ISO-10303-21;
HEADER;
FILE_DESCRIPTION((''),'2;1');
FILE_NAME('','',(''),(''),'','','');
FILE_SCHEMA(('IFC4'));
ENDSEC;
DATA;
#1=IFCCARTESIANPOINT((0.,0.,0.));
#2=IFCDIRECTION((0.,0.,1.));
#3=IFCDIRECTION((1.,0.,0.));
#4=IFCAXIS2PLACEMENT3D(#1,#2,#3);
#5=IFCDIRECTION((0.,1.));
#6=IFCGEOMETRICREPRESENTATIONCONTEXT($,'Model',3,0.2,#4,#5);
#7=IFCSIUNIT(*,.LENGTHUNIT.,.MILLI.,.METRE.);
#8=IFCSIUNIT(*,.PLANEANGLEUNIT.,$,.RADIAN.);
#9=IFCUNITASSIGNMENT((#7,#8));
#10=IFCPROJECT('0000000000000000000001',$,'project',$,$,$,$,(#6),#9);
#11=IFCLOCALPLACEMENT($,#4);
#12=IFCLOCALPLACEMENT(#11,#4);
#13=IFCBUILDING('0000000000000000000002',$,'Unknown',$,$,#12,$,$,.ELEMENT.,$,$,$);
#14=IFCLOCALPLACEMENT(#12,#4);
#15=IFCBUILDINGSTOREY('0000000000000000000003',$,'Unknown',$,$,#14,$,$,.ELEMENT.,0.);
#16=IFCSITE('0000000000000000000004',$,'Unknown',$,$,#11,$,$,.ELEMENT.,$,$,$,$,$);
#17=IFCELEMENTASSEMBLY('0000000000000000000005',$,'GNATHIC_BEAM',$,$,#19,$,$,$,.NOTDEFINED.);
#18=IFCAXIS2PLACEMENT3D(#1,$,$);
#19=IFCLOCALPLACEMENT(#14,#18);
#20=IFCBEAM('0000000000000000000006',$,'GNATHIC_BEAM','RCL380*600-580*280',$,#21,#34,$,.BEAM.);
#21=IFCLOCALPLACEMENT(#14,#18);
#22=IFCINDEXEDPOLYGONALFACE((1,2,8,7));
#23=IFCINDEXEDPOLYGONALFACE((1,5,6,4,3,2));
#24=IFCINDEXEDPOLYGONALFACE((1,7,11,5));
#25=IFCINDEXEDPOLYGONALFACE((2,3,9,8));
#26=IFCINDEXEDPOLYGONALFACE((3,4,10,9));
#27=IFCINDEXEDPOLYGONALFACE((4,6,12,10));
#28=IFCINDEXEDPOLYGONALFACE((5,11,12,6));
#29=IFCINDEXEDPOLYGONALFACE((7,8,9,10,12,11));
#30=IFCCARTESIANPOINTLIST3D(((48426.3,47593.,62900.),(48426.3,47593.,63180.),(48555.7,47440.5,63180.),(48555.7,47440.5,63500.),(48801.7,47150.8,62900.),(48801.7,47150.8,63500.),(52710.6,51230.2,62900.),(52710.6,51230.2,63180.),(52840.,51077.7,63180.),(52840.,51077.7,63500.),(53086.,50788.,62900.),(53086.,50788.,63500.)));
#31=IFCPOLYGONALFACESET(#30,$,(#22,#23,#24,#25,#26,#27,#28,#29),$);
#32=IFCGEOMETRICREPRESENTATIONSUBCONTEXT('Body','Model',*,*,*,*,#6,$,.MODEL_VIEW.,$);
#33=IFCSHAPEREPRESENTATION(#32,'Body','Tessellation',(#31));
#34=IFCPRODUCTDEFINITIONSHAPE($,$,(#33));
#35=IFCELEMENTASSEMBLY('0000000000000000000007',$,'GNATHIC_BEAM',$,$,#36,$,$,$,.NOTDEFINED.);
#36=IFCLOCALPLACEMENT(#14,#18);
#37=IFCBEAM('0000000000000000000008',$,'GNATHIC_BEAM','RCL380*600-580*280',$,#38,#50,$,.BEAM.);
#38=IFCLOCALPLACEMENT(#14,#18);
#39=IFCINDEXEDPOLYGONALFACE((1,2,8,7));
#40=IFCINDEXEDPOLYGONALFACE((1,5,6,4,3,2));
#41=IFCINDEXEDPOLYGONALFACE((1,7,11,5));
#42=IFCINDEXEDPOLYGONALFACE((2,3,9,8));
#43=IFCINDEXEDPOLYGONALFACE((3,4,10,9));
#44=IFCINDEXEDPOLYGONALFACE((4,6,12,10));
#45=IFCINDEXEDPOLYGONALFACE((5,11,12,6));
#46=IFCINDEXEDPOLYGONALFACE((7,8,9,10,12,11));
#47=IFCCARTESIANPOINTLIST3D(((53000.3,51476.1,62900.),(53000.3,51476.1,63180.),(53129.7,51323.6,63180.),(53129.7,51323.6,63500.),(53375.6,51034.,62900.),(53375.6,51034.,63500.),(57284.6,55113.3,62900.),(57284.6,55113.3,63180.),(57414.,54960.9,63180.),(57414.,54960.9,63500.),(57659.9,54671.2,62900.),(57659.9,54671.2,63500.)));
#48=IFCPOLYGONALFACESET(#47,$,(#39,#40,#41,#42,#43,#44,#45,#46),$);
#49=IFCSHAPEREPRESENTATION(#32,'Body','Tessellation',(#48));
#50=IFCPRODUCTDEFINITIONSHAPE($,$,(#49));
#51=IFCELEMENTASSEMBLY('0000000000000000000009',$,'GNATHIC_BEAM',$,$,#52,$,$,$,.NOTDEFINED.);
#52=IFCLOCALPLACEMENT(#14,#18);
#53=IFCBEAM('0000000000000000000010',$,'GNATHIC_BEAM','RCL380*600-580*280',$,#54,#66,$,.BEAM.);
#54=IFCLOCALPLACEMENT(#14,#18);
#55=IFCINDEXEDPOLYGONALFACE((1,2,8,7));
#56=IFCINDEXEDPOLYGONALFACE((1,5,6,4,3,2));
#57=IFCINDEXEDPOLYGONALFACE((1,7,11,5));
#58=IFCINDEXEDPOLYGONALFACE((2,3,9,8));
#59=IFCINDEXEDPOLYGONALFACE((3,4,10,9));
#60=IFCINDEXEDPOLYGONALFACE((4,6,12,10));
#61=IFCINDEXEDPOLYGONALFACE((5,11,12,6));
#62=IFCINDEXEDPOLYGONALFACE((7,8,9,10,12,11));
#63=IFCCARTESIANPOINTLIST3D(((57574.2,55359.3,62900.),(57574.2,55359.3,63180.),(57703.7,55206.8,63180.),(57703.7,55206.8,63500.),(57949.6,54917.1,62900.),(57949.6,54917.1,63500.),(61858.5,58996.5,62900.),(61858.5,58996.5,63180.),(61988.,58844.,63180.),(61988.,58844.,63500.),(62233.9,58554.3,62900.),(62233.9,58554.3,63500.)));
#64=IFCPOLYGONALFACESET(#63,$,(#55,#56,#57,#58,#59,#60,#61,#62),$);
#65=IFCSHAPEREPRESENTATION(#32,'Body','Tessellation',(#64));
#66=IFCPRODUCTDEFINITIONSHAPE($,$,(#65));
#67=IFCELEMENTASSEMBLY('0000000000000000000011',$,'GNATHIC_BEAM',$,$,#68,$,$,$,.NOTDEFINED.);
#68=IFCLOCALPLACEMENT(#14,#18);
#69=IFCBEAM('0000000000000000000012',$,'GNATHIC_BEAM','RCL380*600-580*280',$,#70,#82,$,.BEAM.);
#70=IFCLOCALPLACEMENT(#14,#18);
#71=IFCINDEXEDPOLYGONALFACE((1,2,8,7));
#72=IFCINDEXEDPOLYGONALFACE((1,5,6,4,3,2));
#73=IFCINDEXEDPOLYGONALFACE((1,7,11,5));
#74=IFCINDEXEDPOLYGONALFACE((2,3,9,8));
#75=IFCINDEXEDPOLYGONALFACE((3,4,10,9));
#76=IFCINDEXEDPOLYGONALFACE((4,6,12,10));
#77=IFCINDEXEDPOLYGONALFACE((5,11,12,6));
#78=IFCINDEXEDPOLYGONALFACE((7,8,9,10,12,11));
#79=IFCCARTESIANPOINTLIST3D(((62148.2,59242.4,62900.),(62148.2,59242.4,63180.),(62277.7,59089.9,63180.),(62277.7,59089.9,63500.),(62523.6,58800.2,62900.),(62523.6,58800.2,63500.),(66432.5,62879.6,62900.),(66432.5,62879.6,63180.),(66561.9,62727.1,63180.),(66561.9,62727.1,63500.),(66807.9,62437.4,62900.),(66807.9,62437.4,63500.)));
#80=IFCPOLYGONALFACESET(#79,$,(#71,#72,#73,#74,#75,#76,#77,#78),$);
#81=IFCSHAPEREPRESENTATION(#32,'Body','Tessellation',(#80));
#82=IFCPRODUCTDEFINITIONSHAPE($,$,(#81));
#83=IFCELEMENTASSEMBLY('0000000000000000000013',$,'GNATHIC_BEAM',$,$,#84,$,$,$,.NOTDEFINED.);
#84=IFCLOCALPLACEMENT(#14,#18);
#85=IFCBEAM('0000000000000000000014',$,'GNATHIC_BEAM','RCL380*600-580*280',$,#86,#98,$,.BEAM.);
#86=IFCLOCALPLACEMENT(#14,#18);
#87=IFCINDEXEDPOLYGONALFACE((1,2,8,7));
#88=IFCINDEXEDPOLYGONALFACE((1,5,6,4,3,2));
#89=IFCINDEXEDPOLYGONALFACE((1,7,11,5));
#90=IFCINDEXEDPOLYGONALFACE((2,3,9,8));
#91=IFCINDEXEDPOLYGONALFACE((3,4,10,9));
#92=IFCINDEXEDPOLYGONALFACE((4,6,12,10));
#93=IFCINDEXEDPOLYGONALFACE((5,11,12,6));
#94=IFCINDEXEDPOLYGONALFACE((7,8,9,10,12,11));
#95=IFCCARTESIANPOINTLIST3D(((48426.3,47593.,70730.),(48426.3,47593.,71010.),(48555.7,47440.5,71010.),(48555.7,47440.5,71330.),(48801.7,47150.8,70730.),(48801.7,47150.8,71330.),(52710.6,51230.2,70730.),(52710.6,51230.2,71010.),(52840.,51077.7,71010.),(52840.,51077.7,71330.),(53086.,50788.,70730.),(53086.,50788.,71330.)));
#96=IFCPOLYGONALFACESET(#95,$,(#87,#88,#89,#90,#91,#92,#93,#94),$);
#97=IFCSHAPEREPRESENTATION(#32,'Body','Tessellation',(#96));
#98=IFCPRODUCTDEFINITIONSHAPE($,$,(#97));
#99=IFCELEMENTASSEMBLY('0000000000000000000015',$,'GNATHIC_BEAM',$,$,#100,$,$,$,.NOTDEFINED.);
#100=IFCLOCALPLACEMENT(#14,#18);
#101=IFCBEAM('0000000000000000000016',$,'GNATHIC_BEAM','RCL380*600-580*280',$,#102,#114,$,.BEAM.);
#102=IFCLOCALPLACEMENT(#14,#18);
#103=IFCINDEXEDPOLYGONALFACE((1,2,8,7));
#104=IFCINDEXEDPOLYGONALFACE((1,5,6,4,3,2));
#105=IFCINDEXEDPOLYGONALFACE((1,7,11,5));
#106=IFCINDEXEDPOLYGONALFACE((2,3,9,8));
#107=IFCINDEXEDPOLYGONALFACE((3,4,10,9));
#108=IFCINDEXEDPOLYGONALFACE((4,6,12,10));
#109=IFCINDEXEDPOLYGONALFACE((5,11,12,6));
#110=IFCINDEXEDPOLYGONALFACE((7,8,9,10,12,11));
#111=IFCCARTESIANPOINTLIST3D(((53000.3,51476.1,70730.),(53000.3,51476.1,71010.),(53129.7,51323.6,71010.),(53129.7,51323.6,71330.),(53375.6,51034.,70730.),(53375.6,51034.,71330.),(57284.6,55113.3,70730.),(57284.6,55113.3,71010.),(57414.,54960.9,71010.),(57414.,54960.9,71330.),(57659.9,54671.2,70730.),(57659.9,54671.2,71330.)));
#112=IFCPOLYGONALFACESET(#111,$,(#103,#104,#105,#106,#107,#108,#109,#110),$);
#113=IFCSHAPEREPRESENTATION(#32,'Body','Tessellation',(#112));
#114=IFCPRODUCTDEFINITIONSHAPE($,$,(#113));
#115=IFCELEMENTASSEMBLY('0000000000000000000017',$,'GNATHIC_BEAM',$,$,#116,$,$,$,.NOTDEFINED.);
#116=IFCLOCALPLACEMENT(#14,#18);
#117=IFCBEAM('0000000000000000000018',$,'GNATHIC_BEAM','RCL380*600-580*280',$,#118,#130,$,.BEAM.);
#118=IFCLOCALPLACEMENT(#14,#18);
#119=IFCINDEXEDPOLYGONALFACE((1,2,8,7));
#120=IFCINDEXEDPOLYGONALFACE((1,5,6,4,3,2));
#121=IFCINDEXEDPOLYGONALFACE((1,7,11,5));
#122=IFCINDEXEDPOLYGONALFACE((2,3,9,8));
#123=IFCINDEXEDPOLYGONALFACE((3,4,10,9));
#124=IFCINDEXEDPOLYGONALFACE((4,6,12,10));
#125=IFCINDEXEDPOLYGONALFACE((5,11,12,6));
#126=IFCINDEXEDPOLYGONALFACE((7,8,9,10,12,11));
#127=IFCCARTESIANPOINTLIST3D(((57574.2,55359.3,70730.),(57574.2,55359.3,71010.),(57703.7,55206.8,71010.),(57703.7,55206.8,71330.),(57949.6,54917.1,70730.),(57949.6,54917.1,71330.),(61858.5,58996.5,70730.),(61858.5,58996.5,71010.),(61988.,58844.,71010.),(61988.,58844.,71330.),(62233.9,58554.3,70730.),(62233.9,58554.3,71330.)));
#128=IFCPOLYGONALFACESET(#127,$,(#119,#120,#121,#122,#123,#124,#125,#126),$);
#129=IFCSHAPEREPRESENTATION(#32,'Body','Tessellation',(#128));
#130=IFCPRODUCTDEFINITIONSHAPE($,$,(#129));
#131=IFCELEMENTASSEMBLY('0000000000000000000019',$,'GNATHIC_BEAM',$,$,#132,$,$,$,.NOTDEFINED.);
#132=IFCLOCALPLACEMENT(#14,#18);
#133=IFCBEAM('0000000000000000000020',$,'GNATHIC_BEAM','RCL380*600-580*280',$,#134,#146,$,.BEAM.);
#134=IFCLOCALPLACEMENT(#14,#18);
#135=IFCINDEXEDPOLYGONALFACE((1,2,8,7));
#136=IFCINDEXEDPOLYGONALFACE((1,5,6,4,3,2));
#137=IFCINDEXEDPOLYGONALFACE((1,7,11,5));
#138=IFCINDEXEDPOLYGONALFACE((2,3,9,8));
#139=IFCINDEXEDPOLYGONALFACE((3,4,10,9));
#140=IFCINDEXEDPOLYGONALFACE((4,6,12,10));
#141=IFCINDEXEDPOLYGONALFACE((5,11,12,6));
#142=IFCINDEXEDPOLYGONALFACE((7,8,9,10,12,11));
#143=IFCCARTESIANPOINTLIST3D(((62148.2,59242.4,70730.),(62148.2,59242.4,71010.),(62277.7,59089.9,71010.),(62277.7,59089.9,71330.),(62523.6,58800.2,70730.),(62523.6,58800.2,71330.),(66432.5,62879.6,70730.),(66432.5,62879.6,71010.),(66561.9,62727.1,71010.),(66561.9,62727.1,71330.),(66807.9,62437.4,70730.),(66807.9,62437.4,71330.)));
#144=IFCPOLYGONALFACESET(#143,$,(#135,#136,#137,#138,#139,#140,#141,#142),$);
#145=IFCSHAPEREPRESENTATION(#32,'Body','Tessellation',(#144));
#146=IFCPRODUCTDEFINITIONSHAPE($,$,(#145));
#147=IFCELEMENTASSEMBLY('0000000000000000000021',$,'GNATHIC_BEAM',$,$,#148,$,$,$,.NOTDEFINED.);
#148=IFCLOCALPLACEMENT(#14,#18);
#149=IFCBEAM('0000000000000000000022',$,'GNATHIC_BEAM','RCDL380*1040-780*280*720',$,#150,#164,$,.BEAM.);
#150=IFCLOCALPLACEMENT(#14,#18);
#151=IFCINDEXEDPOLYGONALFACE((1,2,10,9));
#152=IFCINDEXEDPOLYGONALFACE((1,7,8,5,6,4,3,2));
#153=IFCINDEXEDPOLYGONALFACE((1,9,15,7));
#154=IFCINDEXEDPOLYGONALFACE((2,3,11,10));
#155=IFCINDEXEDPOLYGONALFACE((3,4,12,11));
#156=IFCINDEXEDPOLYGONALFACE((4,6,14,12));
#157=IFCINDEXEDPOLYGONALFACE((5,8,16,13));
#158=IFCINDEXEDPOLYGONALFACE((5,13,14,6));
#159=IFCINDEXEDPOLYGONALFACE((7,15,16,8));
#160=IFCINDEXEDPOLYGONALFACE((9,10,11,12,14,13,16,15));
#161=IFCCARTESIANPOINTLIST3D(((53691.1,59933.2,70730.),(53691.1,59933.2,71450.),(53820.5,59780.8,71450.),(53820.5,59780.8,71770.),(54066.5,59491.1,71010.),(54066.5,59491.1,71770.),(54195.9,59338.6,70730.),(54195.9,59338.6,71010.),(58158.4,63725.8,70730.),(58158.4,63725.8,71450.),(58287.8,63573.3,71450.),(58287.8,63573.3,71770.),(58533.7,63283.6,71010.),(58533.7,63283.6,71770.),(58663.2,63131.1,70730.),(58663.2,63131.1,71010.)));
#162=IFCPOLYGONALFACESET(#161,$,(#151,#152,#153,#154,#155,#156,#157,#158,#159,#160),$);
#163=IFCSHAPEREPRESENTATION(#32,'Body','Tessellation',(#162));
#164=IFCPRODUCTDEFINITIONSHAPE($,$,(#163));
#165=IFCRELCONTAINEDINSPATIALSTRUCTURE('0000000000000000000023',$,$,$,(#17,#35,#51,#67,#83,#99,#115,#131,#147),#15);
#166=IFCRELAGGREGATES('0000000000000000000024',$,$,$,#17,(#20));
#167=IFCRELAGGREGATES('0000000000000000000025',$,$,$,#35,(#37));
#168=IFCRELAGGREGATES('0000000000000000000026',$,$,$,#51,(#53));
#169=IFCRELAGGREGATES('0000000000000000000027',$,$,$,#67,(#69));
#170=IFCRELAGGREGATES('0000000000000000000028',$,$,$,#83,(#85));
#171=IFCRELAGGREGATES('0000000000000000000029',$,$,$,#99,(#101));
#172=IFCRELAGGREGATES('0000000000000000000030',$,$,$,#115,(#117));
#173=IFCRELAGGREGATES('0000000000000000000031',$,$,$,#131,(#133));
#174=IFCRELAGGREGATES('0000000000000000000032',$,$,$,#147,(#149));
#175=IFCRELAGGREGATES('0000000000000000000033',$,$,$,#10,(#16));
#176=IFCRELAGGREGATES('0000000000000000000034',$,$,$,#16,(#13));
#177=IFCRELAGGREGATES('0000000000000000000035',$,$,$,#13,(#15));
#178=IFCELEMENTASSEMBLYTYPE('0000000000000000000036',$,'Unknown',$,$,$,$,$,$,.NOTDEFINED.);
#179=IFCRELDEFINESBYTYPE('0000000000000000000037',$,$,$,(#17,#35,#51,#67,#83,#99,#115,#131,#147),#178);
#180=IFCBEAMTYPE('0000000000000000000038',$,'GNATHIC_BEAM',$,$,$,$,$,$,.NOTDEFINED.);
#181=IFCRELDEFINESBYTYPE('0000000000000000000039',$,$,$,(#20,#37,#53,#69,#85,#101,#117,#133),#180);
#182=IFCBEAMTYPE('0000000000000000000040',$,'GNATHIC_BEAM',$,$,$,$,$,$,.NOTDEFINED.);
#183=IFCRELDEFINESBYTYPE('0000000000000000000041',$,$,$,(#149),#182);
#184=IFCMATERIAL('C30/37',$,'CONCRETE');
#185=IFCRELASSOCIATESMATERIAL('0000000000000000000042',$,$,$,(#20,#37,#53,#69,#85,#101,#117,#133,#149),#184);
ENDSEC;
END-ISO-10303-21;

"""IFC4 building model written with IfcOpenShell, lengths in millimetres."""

from ifc_helpers import new_model, si_unit, direction, frame, origin_with_axes, place, context, subcontext, project, spatial, polyline, outline, extrude, material, material_profile, profile_set, profile_usage, type_object, element, aggregate, save


model = new_model("IFC4")

# Units and contexts
model_context = context("Model", 3, precision=0.2, world=origin_with_axes(), true_north=direction((0.0, 1.0)))
body_context = subcontext(model_context, "Body", "Model", "MODEL_VIEW")
ifc_project = project(units=[si_unit("LENGTHUNIT", "METRE", prefix="MILLI"), si_unit("PLANEANGLEUNIT", "RADIAN")], contexts=[model_context])

# Site, building, storey
site_placement = place(None, origin_with_axes())
site = spatial("IfcSite", under=ifc_project, at=site_placement, Name="Unknown", CompositionType="ELEMENT")
building_placement = place(site_placement, origin_with_axes())
building = spatial("IfcBuilding", under=site, at=building_placement, Name="Unknown", CompositionType="ELEMENT")
storey_placement = place(building_placement, origin_with_axes())
storey = spatial("IfcBuildingStorey", under=building, at=storey_placement, Name="Unknown", CompositionType="ELEMENT", Elevation=0.0)

# Shared definitions
element_assembly_type = type_object("IfcElementAssemblyType", Name="Unknown", PredefinedType="NOTDEFINED")

# Element assemblies, beams
ifc_material_1 = material(Name="C30/37", Category="CONCRETE")
ifc_material_profile_1 = material_profile(ifc_material_1, outline(polyline([(-190.0, -300.0), (390.0, -300.0), (390.0, -20.0), (190.0, -20.0), (190.0, 300.0), (-190.0, 300.0), (-190.0, -300.0)])), Name="RCL380*600-580*280")
ifc_profile_set_1 = profile_set([ifc_material_profile_1])
ifc_profile_usage_1 = profile_usage(ifc_profile_set_1, cardinal=2)
beam_type_1 = type_object("IfcBeamType", Name="GNATHIC_BEAM")
assembly_1_placement = place(storey_placement, frame((52963.0, 50932.9, 63200.0), z_axis=(-0.64719, 0.762329, 0.0), x_axis=(-0.762329, -0.64719, 0.0)))
assembly_1 = element("IfcElementAssembly", 1, at=assembly_1_placement, inside=storey, type_object=element_assembly_type, Name="GNATHIC_BEAM", PredefinedType="NOTDEFINED")
beam_1_placement = place(assembly_1_placement, origin_with_axes())
beam_1 = element("IfcBeam", 2, at=beam_1_placement, type_object=beam_type_1, material=ifc_profile_usage_1, Name="GNATHIC_BEAM", Description="RCL380*600-580*280", PredefinedType="BEAM", context=body_context, shape_type="SolidModel", body=[
    extrude(outline(polyline([(-190.0, -300.0), (390.0, -300.0), (390.0, -20.0), (190.0, -20.0), (190.0, 300.0), (-190.0, 300.0), (-190.0, -300.0)])), frame((0.0, 0.0, 0.0), z_axis=(-1.0, 0.0, 0.0), x_axis=(0.0, 0.0, 1.0)), (0.0, 0.0, -1.0), 5620.0),
])
aggregate(assembly_1, [beam_1])
assembly_2_placement = place(storey_placement, frame((57537.0, 54816.0, 63200.0), z_axis=(-0.64719, 0.762329, 0.0), x_axis=(-0.762329, -0.64719, 0.0)))
assembly_2 = element("IfcElementAssembly", 3, at=assembly_2_placement, inside=storey, type_object=element_assembly_type, Name="GNATHIC_BEAM", PredefinedType="NOTDEFINED")
beam_2_placement = place(assembly_2_placement, origin_with_axes())
beam_2 = element("IfcBeam", 4, at=beam_2_placement, type_object=beam_type_1, material=ifc_profile_usage_1, Name="GNATHIC_BEAM", Description="RCL380*600-580*280", PredefinedType="BEAM", context=body_context, shape_type="SolidModel", body=[
    extrude(outline(polyline([(-190.0, -300.0), (390.0, -300.0), (390.0, -20.0), (190.0, -20.0), (190.0, 300.0), (-190.0, 300.0), (-190.0, -300.0)])), frame((0.0, 0.0, 0.0), z_axis=(-1.0, 0.0, 0.0), x_axis=(0.0, 0.0, 1.0)), (0.0, 0.0, -1.0), 5620.0),
])
aggregate(assembly_2, [beam_2])
assembly_3_placement = place(storey_placement, frame((62110.9, 58699.2, 63200.0), z_axis=(-0.64719, 0.762329, 0.0), x_axis=(-0.762329, -0.64719, 0.0)))
assembly_3 = element("IfcElementAssembly", 5, at=assembly_3_placement, inside=storey, type_object=element_assembly_type, Name="GNATHIC_BEAM", PredefinedType="NOTDEFINED")
beam_3_placement = place(assembly_3_placement, origin_with_axes())
beam_3 = element("IfcBeam", 6, at=beam_3_placement, type_object=beam_type_1, material=ifc_profile_usage_1, Name="GNATHIC_BEAM", Description="RCL380*600-580*280", PredefinedType="BEAM", context=body_context, shape_type="SolidModel", body=[
    extrude(outline(polyline([(-190.0, -300.0), (390.0, -300.0), (390.0, -20.0), (190.0, -20.0), (190.0, 300.0), (-190.0, 300.0), (-190.0, -300.0)])), frame((0.0, 0.0, 0.0), z_axis=(-1.0, 0.0, 0.0), x_axis=(0.0, 0.0, 1.0)), (0.0, 0.0, -1.0), 5620.0),
])
aggregate(assembly_3, [beam_3])
assembly_4_placement = place(storey_placement, frame((66684.9, 62582.3, 63200.0), z_axis=(-0.64719, 0.762329, 0.0), x_axis=(-0.762329, -0.64719, 0.0)))
assembly_4 = element("IfcElementAssembly", 7, at=assembly_4_placement, inside=storey, type_object=element_assembly_type, Name="GNATHIC_BEAM", PredefinedType="NOTDEFINED")
beam_4_placement = place(assembly_4_placement, origin_with_axes())
beam_4 = element("IfcBeam", 8, at=beam_4_placement, type_object=beam_type_1, material=ifc_profile_usage_1, Name="GNATHIC_BEAM", Description="RCL380*600-580*280", PredefinedType="BEAM", context=body_context, shape_type="SolidModel", body=[
    extrude(outline(polyline([(-190.0, -300.0), (390.0, -300.0), (390.0, -20.0), (190.0, -20.0), (190.0, 300.0), (-190.0, 300.0), (-190.0, -300.0)])), frame((0.0, 0.0, 0.0), z_axis=(-1.0, 0.0, 0.0), x_axis=(0.0, 0.0, 1.0)), (0.0, 0.0, -1.0), 5620.0),
])
aggregate(assembly_4, [beam_4])
assembly_5_placement = place(storey_placement, frame((52963.0, 50932.9, 71030.0), z_axis=(-0.64719, 0.762329, 0.0), x_axis=(-0.762329, -0.64719, 0.0)))
assembly_5 = element("IfcElementAssembly", 9, at=assembly_5_placement, inside=storey, type_object=element_assembly_type, Name="GNATHIC_BEAM", PredefinedType="NOTDEFINED")
beam_5_placement = place(assembly_5_placement, origin_with_axes())
beam_5 = element("IfcBeam", 10, at=beam_5_placement, type_object=beam_type_1, material=ifc_profile_usage_1, Name="GNATHIC_BEAM", Description="RCL380*600-580*280", PredefinedType="BEAM", context=body_context, shape_type="SolidModel", body=[
    extrude(outline(polyline([(-190.0, -300.0), (390.0, -300.0), (390.0, -20.0), (190.0, -20.0), (190.0, 300.0), (-190.0, 300.0), (-190.0, -300.0)])), frame((0.0, 0.0, 0.0), z_axis=(-1.0, 0.0, 0.0), x_axis=(0.0, 0.0, 1.0)), (0.0, 0.0, -1.0), 5620.0),
])
aggregate(assembly_5, [beam_5])
assembly_6_placement = place(storey_placement, frame((57537.0, 54816.0, 71030.0), z_axis=(-0.64719, 0.762329, 0.0), x_axis=(-0.762329, -0.64719, 0.0)))
assembly_6 = element("IfcElementAssembly", 11, at=assembly_6_placement, inside=storey, type_object=element_assembly_type, Name="GNATHIC_BEAM", PredefinedType="NOTDEFINED")
beam_6_placement = place(assembly_6_placement, origin_with_axes())
beam_6 = element("IfcBeam", 12, at=beam_6_placement, type_object=beam_type_1, material=ifc_profile_usage_1, Name="GNATHIC_BEAM", Description="RCL380*600-580*280", PredefinedType="BEAM", context=body_context, shape_type="SolidModel", body=[
    extrude(outline(polyline([(-190.0, -300.0), (390.0, -300.0), (390.0, -20.0), (190.0, -20.0), (190.0, 300.0), (-190.0, 300.0), (-190.0, -300.0)])), frame((0.0, 0.0, 0.0), z_axis=(-1.0, 0.0, 0.0), x_axis=(0.0, 0.0, 1.0)), (0.0, 0.0, -1.0), 5620.0),
])
aggregate(assembly_6, [beam_6])
assembly_7_placement = place(storey_placement, frame((62110.9, 58699.2, 71030.0), z_axis=(-0.64719, 0.762329, 0.0), x_axis=(-0.762329, -0.64719, 0.0)))
assembly_7 = element("IfcElementAssembly", 13, at=assembly_7_placement, inside=storey, type_object=element_assembly_type, Name="GNATHIC_BEAM", PredefinedType="NOTDEFINED")
beam_7_placement = place(assembly_7_placement, origin_with_axes())
beam_7 = element("IfcBeam", 14, at=beam_7_placement, type_object=beam_type_1, material=ifc_profile_usage_1, Name="GNATHIC_BEAM", Description="RCL380*600-580*280", PredefinedType="BEAM", context=body_context, shape_type="SolidModel", body=[
    extrude(outline(polyline([(-190.0, -300.0), (390.0, -300.0), (390.0, -20.0), (190.0, -20.0), (190.0, 300.0), (-190.0, 300.0), (-190.0, -300.0)])), frame((0.0, 0.0, 0.0), z_axis=(-1.0, 0.0, 0.0), x_axis=(0.0, 0.0, 1.0)), (0.0, 0.0, -1.0), 5620.0),
])
aggregate(assembly_7, [beam_7])
assembly_8_placement = place(storey_placement, frame((66684.9, 62582.3, 71030.0), z_axis=(-0.64719, 0.762329, 0.0), x_axis=(-0.762329, -0.64719, 0.0)))
assembly_8 = element("IfcElementAssembly", 15, at=assembly_8_placement, inside=storey, type_object=element_assembly_type, Name="GNATHIC_BEAM", PredefinedType="NOTDEFINED")
beam_8_placement = place(assembly_8_placement, origin_with_axes())
beam_8 = element("IfcBeam", 16, at=beam_8_placement, type_object=beam_type_1, material=ifc_profile_usage_1, Name="GNATHIC_BEAM", Description="RCL380*600-580*280", PredefinedType="BEAM", context=body_context, shape_type="SolidModel", body=[
    extrude(outline(polyline([(-190.0, -300.0), (390.0, -300.0), (390.0, -20.0), (190.0, -20.0), (190.0, 300.0), (-190.0, 300.0), (-190.0, -300.0)])), frame((0.0, 0.0, 0.0), z_axis=(-1.0, 0.0, 0.0), x_axis=(0.0, 0.0, 1.0)), (0.0, 0.0, -1.0), 5620.0),
])
aggregate(assembly_8, [beam_8])
assembly_9_placement = place(storey_placement, frame((53943.5, 59635.9, 71250.0), z_axis=(0.64719, -0.762329, 0.0), x_axis=(0.762329, 0.64719, 0.0)))
assembly_9 = element("IfcElementAssembly", 17, at=assembly_9_placement, inside=storey, type_object=element_assembly_type, Name="GNATHIC_BEAM", PredefinedType="NOTDEFINED")
ifc_material_profile_2 = material_profile(ifc_material_1, outline(polyline([(-390.0, -520.0), (390.0, -520.0), (390.0, -240.0), (190.0, -240.0), (190.0, 520.0), (-190.0, 520.0), (-190.0, 200.0), (-390.0, 200.0), (-390.0, -520.0)])), Name="RCDL380*1040-780*280*720")
ifc_profile_set_2 = profile_set([ifc_material_profile_2])
ifc_profile_usage_2 = profile_usage(ifc_profile_set_2, cardinal=2)
beam_type_2 = type_object("IfcBeamType", Name="GNATHIC_BEAM")
beam_9_placement = place(assembly_9_placement, origin_with_axes())
beam_9 = element("IfcBeam", 18, at=beam_9_placement, type_object=beam_type_2, material=ifc_profile_usage_2, Name="GNATHIC_BEAM", Description="RCDL380*1040-780*280*720", PredefinedType="BEAM", context=body_context, shape_type="SolidModel", body=[
    extrude(outline(polyline([(-390.0, -520.0), (390.0, -520.0), (390.0, -240.0), (190.0, -240.0), (190.0, 520.0), (-190.0, 520.0), (-190.0, 200.0), (-390.0, 200.0), (-390.0, -520.0)])), frame((0.0, 0.0, 0.0), z_axis=(-1.0, 0.0, 0.0), x_axis=(0.0, 0.0, 1.0)), (0.0, 0.0, -1.0), 5860.0),
])
aggregate(assembly_9, [beam_9])

save(model, "model.ifc")
